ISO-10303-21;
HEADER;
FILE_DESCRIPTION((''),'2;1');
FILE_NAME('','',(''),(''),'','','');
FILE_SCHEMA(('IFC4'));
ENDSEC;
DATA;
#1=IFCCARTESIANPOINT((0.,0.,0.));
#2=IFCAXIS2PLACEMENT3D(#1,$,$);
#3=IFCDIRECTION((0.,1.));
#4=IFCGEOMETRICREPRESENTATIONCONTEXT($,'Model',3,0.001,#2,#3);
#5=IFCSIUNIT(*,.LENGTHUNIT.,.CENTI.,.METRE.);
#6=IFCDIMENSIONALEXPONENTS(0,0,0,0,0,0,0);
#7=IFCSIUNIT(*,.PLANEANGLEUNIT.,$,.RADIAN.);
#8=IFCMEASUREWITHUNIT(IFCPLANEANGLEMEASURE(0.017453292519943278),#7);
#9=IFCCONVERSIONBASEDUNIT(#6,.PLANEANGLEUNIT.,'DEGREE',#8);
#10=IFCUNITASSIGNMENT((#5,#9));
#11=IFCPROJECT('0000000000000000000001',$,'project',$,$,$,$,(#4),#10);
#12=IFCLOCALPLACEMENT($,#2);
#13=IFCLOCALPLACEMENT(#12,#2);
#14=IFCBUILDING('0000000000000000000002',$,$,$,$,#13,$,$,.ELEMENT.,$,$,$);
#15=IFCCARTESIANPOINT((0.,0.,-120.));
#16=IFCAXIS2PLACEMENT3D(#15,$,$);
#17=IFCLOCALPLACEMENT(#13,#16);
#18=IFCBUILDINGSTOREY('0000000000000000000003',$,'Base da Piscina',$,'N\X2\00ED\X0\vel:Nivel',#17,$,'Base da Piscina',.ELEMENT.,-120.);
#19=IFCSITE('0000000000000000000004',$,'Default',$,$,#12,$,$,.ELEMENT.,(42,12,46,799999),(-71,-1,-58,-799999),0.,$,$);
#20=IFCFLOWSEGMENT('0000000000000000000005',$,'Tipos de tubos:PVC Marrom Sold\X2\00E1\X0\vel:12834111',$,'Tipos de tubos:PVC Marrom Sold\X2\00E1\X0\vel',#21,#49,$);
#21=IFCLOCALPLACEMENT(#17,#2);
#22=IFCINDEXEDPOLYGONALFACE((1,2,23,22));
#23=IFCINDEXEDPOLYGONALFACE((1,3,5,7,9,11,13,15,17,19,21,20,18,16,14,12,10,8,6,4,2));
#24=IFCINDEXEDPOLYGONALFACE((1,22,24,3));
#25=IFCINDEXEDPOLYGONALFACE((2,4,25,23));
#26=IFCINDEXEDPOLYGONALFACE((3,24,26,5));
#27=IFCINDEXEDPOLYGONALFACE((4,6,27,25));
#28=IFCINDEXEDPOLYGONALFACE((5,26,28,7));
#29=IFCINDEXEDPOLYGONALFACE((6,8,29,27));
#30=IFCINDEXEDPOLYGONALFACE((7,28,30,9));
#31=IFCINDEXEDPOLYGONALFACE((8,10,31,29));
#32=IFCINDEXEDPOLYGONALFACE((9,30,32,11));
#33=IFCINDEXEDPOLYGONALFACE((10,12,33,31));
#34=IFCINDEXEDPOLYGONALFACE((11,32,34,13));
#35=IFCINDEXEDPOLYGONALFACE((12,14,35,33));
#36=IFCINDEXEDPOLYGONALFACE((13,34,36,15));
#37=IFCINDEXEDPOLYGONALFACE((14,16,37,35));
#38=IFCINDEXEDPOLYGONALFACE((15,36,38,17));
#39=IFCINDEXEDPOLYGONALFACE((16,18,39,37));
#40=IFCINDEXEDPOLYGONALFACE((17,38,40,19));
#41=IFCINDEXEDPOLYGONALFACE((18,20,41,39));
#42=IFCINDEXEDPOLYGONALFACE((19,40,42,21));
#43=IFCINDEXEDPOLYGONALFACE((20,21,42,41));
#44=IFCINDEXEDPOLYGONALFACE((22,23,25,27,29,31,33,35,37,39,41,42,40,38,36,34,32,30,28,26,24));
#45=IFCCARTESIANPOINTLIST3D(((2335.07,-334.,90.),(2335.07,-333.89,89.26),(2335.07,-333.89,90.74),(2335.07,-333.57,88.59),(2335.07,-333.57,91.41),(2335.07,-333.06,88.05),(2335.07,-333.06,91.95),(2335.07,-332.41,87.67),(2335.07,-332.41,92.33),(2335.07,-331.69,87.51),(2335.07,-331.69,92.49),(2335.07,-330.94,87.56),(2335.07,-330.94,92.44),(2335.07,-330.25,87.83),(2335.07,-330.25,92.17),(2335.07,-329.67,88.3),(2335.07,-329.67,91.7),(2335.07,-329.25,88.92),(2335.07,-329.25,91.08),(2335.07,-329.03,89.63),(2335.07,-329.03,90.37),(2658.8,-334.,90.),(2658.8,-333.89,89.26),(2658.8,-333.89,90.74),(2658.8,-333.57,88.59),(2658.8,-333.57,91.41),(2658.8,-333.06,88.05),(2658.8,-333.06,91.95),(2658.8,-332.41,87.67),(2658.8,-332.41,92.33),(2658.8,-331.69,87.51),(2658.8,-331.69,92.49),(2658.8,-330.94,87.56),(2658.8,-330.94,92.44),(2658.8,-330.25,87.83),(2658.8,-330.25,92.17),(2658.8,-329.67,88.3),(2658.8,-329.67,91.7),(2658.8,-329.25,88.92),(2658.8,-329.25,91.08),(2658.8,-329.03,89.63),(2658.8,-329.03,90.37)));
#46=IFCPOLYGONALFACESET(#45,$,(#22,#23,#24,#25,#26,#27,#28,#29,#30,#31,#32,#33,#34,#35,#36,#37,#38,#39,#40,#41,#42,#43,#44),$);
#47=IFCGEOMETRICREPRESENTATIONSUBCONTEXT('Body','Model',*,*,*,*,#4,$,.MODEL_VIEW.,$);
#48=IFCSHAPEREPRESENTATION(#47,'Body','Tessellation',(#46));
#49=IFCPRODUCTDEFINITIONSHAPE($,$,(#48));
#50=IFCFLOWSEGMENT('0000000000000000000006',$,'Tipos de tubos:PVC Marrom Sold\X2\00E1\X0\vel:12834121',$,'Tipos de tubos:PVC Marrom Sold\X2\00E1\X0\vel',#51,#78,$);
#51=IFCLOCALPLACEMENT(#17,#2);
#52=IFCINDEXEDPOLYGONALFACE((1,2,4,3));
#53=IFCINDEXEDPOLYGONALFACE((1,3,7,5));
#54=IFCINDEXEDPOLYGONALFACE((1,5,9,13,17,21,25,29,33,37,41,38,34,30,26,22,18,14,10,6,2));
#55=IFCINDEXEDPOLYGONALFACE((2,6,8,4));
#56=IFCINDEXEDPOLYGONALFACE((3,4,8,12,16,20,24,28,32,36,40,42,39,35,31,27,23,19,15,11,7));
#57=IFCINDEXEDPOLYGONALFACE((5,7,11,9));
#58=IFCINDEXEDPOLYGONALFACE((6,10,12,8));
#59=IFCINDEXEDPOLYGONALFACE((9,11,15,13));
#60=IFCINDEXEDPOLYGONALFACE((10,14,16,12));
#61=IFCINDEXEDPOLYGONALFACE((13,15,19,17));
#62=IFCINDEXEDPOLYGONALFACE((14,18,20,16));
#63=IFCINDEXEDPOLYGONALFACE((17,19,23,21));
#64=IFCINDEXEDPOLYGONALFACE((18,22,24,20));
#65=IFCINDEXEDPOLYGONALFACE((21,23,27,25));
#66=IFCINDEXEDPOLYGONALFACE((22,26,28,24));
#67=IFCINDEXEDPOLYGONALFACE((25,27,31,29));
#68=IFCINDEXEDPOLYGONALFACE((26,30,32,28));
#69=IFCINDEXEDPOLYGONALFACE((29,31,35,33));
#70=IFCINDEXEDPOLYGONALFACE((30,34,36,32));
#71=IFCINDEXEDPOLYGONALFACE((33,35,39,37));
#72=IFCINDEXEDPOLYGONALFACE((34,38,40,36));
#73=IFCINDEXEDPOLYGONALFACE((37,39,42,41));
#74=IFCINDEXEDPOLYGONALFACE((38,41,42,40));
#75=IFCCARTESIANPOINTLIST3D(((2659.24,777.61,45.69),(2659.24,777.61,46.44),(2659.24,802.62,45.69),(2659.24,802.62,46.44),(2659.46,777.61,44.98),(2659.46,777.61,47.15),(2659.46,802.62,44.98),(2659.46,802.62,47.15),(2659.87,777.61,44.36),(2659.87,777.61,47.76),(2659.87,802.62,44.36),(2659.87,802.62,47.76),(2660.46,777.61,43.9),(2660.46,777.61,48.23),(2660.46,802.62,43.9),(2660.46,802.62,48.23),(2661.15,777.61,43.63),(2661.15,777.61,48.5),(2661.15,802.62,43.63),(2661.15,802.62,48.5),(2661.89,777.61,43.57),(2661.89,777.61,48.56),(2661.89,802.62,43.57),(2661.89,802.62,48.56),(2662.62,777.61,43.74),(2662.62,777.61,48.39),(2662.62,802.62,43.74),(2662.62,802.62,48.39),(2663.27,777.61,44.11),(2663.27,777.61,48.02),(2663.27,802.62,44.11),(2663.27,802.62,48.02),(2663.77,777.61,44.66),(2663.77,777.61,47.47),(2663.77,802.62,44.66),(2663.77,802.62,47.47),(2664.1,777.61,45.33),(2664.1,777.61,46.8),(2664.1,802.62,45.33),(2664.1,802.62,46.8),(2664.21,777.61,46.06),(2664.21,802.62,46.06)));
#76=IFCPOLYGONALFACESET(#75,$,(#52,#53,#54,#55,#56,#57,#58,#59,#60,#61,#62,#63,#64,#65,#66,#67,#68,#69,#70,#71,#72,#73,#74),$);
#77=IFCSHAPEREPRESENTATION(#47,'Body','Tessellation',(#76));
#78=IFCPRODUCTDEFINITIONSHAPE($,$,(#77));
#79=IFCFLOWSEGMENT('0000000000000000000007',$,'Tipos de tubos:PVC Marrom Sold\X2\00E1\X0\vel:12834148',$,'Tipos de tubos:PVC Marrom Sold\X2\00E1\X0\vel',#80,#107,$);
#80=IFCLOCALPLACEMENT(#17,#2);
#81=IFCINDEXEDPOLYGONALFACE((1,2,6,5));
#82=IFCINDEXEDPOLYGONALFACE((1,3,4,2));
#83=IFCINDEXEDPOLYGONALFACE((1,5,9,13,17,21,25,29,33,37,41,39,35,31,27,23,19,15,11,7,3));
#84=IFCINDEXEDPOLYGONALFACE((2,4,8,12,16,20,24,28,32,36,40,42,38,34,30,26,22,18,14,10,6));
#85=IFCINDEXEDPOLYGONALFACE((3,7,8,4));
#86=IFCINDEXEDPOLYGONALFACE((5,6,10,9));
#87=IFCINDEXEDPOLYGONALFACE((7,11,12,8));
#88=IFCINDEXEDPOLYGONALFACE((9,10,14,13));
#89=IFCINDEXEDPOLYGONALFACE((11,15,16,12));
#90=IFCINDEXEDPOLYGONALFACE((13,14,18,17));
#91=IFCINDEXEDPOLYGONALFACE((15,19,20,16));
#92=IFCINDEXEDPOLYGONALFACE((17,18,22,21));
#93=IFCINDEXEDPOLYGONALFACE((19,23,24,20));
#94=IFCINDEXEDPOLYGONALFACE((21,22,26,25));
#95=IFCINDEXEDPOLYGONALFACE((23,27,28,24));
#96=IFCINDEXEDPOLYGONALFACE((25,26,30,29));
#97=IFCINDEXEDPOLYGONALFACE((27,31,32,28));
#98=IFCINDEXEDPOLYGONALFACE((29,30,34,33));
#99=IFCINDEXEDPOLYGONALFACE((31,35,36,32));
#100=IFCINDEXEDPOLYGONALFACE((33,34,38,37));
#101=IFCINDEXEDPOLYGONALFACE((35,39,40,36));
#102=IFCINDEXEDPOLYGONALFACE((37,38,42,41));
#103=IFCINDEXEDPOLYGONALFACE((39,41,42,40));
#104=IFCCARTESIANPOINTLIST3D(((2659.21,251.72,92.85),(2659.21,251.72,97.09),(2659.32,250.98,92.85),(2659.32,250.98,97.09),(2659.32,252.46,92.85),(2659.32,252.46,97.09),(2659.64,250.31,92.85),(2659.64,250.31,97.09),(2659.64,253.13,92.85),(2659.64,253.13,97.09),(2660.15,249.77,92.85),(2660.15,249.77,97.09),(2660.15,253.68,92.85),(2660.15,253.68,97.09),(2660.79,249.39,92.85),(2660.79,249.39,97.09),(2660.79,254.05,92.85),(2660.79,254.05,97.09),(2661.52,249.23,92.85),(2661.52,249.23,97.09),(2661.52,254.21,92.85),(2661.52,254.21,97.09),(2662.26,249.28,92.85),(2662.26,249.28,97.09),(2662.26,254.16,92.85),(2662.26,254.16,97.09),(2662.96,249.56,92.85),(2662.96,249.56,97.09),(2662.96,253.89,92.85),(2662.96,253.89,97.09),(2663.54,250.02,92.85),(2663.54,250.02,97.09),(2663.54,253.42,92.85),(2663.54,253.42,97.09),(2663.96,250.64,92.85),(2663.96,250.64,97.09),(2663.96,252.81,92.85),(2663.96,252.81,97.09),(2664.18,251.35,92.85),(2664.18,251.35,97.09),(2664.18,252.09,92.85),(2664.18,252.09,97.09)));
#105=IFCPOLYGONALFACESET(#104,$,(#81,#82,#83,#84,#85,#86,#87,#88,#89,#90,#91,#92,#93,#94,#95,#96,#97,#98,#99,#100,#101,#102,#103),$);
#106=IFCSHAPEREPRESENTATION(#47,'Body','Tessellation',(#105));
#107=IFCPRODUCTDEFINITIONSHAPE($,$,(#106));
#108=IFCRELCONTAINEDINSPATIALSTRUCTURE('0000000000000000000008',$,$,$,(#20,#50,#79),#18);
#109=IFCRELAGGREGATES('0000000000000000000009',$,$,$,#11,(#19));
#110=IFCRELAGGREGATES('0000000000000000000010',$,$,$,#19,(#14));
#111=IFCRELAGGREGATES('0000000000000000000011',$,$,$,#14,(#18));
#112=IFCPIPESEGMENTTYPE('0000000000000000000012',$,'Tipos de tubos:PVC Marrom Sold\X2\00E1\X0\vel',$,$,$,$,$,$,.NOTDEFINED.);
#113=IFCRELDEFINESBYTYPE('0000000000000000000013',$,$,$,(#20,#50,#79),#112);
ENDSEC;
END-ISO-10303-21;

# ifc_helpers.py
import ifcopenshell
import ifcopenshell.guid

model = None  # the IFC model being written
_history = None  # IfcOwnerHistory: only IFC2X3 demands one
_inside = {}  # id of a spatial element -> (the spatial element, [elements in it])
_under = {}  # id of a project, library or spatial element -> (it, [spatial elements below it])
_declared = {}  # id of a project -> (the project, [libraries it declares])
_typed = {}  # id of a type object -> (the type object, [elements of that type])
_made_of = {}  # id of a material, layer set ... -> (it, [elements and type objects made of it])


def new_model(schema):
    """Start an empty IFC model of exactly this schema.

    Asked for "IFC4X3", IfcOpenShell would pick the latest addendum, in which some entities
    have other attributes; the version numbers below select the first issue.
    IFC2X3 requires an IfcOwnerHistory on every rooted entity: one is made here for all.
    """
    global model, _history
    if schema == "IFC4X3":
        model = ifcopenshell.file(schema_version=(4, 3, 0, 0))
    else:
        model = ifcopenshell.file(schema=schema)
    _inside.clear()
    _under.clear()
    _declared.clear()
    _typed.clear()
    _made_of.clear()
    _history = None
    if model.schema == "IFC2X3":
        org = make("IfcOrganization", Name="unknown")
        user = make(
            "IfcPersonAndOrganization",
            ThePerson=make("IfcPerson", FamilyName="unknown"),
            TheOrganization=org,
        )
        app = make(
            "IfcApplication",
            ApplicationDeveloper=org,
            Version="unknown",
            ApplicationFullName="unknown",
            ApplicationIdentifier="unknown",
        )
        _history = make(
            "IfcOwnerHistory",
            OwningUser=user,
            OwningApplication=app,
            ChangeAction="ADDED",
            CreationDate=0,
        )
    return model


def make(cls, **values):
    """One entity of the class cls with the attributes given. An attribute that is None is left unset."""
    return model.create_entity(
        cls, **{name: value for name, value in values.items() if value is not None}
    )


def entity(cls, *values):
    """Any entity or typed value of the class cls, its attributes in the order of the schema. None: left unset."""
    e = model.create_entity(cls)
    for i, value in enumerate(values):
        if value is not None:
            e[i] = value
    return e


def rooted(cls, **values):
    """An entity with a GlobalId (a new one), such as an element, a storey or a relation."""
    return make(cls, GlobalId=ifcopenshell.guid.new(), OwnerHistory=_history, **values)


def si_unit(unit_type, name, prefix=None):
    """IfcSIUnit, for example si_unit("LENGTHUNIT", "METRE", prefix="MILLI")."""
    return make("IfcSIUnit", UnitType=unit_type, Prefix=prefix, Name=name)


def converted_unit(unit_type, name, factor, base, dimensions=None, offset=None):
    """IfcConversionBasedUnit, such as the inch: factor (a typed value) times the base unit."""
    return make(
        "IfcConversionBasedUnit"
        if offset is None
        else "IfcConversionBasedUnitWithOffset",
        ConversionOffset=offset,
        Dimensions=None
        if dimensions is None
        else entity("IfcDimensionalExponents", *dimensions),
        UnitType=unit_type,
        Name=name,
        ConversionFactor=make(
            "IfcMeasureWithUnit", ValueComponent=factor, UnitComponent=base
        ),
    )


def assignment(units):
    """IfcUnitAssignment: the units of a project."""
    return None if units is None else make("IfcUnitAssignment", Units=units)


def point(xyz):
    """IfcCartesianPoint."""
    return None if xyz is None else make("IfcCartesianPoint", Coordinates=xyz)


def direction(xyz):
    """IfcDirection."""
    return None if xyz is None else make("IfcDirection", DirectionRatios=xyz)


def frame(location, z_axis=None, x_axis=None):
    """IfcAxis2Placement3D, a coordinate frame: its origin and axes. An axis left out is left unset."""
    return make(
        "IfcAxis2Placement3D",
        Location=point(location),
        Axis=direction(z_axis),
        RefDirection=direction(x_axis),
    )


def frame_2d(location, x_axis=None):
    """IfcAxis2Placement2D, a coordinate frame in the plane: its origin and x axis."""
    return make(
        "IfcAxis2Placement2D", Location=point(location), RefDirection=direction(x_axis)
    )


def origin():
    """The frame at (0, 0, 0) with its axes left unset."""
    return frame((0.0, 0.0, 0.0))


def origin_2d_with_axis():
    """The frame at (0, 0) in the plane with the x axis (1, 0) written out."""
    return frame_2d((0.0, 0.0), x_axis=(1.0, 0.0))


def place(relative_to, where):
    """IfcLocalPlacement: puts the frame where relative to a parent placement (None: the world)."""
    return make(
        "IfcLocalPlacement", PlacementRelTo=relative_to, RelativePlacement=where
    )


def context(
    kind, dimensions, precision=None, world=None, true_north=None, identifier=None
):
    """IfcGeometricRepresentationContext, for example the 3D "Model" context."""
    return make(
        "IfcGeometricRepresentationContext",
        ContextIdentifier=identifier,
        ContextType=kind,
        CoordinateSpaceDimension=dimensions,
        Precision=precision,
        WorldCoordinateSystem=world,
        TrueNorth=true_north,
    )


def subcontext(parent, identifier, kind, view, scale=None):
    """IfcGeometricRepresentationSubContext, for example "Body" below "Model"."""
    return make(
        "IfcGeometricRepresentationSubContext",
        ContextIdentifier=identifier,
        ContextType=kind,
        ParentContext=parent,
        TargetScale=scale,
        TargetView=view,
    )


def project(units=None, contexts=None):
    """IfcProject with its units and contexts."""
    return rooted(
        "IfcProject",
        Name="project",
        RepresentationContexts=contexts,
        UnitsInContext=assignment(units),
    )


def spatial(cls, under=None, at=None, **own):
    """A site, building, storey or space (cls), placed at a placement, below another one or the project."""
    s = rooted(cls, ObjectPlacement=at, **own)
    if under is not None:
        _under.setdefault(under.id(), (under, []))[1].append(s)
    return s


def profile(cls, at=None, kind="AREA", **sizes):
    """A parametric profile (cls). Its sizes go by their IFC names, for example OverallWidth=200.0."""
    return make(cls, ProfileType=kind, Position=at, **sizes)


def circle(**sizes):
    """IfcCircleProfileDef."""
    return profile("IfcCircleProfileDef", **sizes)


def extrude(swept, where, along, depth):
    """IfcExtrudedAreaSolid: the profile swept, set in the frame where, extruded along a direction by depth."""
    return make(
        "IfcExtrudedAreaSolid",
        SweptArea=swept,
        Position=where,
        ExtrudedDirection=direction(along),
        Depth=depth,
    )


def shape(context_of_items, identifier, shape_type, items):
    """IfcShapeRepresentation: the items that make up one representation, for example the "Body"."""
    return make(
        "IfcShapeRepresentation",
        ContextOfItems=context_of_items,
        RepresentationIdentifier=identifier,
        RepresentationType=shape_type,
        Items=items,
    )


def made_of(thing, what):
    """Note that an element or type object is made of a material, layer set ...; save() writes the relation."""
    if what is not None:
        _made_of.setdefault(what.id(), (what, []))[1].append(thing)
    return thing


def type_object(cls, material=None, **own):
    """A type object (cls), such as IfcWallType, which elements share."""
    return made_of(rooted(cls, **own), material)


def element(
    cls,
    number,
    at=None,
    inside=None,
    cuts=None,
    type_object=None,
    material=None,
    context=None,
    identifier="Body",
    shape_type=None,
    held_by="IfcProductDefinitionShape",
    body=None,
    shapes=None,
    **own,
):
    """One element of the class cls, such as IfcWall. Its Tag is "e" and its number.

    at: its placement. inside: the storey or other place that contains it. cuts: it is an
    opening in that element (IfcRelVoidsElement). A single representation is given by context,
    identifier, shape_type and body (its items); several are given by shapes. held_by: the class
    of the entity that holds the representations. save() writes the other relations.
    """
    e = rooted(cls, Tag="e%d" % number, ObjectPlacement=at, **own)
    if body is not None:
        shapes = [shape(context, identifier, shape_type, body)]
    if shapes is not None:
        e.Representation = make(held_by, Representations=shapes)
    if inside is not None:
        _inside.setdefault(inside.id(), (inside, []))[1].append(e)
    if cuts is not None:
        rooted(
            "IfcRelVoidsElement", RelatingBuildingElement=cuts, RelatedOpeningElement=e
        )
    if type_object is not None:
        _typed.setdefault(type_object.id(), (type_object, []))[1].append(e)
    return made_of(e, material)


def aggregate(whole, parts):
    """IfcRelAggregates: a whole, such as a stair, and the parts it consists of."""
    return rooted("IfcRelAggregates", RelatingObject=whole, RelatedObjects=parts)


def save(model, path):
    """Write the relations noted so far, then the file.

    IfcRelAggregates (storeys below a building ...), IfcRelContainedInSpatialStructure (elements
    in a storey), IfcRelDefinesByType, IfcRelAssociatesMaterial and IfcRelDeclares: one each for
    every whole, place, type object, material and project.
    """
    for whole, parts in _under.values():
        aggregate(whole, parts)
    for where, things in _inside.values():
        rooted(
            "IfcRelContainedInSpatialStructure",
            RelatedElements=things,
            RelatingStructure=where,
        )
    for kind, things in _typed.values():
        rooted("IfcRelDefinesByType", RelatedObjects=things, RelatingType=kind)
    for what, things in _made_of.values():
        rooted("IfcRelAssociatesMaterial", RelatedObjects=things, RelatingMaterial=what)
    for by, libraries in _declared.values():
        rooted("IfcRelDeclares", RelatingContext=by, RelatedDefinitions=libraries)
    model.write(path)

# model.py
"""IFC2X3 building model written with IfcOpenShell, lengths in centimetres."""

from ifc_helpers import new_model, entity, si_unit, converted_unit, direction, frame, frame_2d, origin, origin_2d_with_axis, place, context, subcontext, project, spatial, circle, extrude, type_object, element, save


model = new_model("IFC2X3")

# Units and contexts
model_context = context("Model", 3, precision=0.001, world=origin(), true_north=direction((0.0, 1.0)))
body_context = subcontext(model_context, "Body", "Model", "MODEL_VIEW")
ifc_project = project(units=[si_unit("LENGTHUNIT", "METRE", prefix="CENTI"), converted_unit("PLANEANGLEUNIT", "DEGREE", entity("IfcPlaneAngleMeasure", 0.017453292519943278), si_unit("PLANEANGLEUNIT", "RADIAN"), dimensions=[0, 0, 0, 0, 0, 0, 0])], contexts=[model_context])

# Site, building, storey
site_placement = place(None, origin())
site = spatial("IfcSite", under=ifc_project, at=site_placement, Name="Default", CompositionType="ELEMENT", RefLatitude=(42, 12, 46, 799999), RefLongitude=(-71, -1, -58, -799999), RefElevation=0.0)
building_placement = place(site_placement, origin())
building = spatial("IfcBuilding", under=site, at=building_placement, CompositionType="ELEMENT")
storey_placement = place(building_placement, frame((0.0, 0.0, -120.0)))
storey = spatial("IfcBuildingStorey", under=building, at=storey_placement, Name="Base da Piscina", ObjectType="Nível:Nivel", LongName="Base da Piscina", CompositionType="ELEMENT", Elevation=-120.0)

# Flow segments
pipe_segment_type = type_object("IfcPipeSegmentType", Name="Tipos de tubos:PVC Marrom Soldável", PredefinedType="NOTDEFINED")
flow_segment_1_placement = place(storey_placement, origin())
element("IfcFlowSegment", 1, at=flow_segment_1_placement, inside=storey, type_object=pipe_segment_type, Name="Tipos de tubos:PVC Marrom Soldável:12834111", ObjectType="Tipos de tubos:PVC Marrom Soldável", context=body_context, shape_type="SweptSolid", body=[
    extrude(circle(Radius=2.5, at=frame_2d((0.0, 0.0), x_axis=(1.0, 0.0))), frame((2335.07, -331.5, 90.0), z_axis=(1.0, 0.0, 0.0), x_axis=(0.0, -1.0, 0.0)), (0.0, 0.0, 1.0), 323.73),
])
flow_segment_2_placement = place(storey_placement, origin())
element("IfcFlowSegment", 2, at=flow_segment_2_placement, inside=storey, type_object=pipe_segment_type, Name="Tipos de tubos:PVC Marrom Soldável:12834121", ObjectType="Tipos de tubos:PVC Marrom Soldável", context=body_context, shape_type="SweptSolid", body=[
    extrude(circle(Radius=2.5, at=origin_2d_with_axis()), frame((2661.71, 777.61, 46.06), z_axis=(0.0, 1.0, 0.0), x_axis=(1.0, 0.0, 0.0)), (0.0, 0.0, 1.0), 25.01),
])
flow_segment_3_placement = place(storey_placement, origin())
element("IfcFlowSegment", 3, at=flow_segment_3_placement, inside=storey, type_object=pipe_segment_type, Name="Tipos de tubos:PVC Marrom Soldável:12834148", ObjectType="Tipos de tubos:PVC Marrom Soldável", context=body_context, shape_type="SweptSolid", body=[
    extrude(circle(Radius=2.5, at=origin_2d_with_axis()), frame((2661.71, 251.72, 92.85), z_axis=(0.0, 0.0, 1.0), x_axis=(-1.0, 0.0, 0.0)), (0.0, 0.0, 1.0), 4.24),
])

save(model, "model.ifc")
